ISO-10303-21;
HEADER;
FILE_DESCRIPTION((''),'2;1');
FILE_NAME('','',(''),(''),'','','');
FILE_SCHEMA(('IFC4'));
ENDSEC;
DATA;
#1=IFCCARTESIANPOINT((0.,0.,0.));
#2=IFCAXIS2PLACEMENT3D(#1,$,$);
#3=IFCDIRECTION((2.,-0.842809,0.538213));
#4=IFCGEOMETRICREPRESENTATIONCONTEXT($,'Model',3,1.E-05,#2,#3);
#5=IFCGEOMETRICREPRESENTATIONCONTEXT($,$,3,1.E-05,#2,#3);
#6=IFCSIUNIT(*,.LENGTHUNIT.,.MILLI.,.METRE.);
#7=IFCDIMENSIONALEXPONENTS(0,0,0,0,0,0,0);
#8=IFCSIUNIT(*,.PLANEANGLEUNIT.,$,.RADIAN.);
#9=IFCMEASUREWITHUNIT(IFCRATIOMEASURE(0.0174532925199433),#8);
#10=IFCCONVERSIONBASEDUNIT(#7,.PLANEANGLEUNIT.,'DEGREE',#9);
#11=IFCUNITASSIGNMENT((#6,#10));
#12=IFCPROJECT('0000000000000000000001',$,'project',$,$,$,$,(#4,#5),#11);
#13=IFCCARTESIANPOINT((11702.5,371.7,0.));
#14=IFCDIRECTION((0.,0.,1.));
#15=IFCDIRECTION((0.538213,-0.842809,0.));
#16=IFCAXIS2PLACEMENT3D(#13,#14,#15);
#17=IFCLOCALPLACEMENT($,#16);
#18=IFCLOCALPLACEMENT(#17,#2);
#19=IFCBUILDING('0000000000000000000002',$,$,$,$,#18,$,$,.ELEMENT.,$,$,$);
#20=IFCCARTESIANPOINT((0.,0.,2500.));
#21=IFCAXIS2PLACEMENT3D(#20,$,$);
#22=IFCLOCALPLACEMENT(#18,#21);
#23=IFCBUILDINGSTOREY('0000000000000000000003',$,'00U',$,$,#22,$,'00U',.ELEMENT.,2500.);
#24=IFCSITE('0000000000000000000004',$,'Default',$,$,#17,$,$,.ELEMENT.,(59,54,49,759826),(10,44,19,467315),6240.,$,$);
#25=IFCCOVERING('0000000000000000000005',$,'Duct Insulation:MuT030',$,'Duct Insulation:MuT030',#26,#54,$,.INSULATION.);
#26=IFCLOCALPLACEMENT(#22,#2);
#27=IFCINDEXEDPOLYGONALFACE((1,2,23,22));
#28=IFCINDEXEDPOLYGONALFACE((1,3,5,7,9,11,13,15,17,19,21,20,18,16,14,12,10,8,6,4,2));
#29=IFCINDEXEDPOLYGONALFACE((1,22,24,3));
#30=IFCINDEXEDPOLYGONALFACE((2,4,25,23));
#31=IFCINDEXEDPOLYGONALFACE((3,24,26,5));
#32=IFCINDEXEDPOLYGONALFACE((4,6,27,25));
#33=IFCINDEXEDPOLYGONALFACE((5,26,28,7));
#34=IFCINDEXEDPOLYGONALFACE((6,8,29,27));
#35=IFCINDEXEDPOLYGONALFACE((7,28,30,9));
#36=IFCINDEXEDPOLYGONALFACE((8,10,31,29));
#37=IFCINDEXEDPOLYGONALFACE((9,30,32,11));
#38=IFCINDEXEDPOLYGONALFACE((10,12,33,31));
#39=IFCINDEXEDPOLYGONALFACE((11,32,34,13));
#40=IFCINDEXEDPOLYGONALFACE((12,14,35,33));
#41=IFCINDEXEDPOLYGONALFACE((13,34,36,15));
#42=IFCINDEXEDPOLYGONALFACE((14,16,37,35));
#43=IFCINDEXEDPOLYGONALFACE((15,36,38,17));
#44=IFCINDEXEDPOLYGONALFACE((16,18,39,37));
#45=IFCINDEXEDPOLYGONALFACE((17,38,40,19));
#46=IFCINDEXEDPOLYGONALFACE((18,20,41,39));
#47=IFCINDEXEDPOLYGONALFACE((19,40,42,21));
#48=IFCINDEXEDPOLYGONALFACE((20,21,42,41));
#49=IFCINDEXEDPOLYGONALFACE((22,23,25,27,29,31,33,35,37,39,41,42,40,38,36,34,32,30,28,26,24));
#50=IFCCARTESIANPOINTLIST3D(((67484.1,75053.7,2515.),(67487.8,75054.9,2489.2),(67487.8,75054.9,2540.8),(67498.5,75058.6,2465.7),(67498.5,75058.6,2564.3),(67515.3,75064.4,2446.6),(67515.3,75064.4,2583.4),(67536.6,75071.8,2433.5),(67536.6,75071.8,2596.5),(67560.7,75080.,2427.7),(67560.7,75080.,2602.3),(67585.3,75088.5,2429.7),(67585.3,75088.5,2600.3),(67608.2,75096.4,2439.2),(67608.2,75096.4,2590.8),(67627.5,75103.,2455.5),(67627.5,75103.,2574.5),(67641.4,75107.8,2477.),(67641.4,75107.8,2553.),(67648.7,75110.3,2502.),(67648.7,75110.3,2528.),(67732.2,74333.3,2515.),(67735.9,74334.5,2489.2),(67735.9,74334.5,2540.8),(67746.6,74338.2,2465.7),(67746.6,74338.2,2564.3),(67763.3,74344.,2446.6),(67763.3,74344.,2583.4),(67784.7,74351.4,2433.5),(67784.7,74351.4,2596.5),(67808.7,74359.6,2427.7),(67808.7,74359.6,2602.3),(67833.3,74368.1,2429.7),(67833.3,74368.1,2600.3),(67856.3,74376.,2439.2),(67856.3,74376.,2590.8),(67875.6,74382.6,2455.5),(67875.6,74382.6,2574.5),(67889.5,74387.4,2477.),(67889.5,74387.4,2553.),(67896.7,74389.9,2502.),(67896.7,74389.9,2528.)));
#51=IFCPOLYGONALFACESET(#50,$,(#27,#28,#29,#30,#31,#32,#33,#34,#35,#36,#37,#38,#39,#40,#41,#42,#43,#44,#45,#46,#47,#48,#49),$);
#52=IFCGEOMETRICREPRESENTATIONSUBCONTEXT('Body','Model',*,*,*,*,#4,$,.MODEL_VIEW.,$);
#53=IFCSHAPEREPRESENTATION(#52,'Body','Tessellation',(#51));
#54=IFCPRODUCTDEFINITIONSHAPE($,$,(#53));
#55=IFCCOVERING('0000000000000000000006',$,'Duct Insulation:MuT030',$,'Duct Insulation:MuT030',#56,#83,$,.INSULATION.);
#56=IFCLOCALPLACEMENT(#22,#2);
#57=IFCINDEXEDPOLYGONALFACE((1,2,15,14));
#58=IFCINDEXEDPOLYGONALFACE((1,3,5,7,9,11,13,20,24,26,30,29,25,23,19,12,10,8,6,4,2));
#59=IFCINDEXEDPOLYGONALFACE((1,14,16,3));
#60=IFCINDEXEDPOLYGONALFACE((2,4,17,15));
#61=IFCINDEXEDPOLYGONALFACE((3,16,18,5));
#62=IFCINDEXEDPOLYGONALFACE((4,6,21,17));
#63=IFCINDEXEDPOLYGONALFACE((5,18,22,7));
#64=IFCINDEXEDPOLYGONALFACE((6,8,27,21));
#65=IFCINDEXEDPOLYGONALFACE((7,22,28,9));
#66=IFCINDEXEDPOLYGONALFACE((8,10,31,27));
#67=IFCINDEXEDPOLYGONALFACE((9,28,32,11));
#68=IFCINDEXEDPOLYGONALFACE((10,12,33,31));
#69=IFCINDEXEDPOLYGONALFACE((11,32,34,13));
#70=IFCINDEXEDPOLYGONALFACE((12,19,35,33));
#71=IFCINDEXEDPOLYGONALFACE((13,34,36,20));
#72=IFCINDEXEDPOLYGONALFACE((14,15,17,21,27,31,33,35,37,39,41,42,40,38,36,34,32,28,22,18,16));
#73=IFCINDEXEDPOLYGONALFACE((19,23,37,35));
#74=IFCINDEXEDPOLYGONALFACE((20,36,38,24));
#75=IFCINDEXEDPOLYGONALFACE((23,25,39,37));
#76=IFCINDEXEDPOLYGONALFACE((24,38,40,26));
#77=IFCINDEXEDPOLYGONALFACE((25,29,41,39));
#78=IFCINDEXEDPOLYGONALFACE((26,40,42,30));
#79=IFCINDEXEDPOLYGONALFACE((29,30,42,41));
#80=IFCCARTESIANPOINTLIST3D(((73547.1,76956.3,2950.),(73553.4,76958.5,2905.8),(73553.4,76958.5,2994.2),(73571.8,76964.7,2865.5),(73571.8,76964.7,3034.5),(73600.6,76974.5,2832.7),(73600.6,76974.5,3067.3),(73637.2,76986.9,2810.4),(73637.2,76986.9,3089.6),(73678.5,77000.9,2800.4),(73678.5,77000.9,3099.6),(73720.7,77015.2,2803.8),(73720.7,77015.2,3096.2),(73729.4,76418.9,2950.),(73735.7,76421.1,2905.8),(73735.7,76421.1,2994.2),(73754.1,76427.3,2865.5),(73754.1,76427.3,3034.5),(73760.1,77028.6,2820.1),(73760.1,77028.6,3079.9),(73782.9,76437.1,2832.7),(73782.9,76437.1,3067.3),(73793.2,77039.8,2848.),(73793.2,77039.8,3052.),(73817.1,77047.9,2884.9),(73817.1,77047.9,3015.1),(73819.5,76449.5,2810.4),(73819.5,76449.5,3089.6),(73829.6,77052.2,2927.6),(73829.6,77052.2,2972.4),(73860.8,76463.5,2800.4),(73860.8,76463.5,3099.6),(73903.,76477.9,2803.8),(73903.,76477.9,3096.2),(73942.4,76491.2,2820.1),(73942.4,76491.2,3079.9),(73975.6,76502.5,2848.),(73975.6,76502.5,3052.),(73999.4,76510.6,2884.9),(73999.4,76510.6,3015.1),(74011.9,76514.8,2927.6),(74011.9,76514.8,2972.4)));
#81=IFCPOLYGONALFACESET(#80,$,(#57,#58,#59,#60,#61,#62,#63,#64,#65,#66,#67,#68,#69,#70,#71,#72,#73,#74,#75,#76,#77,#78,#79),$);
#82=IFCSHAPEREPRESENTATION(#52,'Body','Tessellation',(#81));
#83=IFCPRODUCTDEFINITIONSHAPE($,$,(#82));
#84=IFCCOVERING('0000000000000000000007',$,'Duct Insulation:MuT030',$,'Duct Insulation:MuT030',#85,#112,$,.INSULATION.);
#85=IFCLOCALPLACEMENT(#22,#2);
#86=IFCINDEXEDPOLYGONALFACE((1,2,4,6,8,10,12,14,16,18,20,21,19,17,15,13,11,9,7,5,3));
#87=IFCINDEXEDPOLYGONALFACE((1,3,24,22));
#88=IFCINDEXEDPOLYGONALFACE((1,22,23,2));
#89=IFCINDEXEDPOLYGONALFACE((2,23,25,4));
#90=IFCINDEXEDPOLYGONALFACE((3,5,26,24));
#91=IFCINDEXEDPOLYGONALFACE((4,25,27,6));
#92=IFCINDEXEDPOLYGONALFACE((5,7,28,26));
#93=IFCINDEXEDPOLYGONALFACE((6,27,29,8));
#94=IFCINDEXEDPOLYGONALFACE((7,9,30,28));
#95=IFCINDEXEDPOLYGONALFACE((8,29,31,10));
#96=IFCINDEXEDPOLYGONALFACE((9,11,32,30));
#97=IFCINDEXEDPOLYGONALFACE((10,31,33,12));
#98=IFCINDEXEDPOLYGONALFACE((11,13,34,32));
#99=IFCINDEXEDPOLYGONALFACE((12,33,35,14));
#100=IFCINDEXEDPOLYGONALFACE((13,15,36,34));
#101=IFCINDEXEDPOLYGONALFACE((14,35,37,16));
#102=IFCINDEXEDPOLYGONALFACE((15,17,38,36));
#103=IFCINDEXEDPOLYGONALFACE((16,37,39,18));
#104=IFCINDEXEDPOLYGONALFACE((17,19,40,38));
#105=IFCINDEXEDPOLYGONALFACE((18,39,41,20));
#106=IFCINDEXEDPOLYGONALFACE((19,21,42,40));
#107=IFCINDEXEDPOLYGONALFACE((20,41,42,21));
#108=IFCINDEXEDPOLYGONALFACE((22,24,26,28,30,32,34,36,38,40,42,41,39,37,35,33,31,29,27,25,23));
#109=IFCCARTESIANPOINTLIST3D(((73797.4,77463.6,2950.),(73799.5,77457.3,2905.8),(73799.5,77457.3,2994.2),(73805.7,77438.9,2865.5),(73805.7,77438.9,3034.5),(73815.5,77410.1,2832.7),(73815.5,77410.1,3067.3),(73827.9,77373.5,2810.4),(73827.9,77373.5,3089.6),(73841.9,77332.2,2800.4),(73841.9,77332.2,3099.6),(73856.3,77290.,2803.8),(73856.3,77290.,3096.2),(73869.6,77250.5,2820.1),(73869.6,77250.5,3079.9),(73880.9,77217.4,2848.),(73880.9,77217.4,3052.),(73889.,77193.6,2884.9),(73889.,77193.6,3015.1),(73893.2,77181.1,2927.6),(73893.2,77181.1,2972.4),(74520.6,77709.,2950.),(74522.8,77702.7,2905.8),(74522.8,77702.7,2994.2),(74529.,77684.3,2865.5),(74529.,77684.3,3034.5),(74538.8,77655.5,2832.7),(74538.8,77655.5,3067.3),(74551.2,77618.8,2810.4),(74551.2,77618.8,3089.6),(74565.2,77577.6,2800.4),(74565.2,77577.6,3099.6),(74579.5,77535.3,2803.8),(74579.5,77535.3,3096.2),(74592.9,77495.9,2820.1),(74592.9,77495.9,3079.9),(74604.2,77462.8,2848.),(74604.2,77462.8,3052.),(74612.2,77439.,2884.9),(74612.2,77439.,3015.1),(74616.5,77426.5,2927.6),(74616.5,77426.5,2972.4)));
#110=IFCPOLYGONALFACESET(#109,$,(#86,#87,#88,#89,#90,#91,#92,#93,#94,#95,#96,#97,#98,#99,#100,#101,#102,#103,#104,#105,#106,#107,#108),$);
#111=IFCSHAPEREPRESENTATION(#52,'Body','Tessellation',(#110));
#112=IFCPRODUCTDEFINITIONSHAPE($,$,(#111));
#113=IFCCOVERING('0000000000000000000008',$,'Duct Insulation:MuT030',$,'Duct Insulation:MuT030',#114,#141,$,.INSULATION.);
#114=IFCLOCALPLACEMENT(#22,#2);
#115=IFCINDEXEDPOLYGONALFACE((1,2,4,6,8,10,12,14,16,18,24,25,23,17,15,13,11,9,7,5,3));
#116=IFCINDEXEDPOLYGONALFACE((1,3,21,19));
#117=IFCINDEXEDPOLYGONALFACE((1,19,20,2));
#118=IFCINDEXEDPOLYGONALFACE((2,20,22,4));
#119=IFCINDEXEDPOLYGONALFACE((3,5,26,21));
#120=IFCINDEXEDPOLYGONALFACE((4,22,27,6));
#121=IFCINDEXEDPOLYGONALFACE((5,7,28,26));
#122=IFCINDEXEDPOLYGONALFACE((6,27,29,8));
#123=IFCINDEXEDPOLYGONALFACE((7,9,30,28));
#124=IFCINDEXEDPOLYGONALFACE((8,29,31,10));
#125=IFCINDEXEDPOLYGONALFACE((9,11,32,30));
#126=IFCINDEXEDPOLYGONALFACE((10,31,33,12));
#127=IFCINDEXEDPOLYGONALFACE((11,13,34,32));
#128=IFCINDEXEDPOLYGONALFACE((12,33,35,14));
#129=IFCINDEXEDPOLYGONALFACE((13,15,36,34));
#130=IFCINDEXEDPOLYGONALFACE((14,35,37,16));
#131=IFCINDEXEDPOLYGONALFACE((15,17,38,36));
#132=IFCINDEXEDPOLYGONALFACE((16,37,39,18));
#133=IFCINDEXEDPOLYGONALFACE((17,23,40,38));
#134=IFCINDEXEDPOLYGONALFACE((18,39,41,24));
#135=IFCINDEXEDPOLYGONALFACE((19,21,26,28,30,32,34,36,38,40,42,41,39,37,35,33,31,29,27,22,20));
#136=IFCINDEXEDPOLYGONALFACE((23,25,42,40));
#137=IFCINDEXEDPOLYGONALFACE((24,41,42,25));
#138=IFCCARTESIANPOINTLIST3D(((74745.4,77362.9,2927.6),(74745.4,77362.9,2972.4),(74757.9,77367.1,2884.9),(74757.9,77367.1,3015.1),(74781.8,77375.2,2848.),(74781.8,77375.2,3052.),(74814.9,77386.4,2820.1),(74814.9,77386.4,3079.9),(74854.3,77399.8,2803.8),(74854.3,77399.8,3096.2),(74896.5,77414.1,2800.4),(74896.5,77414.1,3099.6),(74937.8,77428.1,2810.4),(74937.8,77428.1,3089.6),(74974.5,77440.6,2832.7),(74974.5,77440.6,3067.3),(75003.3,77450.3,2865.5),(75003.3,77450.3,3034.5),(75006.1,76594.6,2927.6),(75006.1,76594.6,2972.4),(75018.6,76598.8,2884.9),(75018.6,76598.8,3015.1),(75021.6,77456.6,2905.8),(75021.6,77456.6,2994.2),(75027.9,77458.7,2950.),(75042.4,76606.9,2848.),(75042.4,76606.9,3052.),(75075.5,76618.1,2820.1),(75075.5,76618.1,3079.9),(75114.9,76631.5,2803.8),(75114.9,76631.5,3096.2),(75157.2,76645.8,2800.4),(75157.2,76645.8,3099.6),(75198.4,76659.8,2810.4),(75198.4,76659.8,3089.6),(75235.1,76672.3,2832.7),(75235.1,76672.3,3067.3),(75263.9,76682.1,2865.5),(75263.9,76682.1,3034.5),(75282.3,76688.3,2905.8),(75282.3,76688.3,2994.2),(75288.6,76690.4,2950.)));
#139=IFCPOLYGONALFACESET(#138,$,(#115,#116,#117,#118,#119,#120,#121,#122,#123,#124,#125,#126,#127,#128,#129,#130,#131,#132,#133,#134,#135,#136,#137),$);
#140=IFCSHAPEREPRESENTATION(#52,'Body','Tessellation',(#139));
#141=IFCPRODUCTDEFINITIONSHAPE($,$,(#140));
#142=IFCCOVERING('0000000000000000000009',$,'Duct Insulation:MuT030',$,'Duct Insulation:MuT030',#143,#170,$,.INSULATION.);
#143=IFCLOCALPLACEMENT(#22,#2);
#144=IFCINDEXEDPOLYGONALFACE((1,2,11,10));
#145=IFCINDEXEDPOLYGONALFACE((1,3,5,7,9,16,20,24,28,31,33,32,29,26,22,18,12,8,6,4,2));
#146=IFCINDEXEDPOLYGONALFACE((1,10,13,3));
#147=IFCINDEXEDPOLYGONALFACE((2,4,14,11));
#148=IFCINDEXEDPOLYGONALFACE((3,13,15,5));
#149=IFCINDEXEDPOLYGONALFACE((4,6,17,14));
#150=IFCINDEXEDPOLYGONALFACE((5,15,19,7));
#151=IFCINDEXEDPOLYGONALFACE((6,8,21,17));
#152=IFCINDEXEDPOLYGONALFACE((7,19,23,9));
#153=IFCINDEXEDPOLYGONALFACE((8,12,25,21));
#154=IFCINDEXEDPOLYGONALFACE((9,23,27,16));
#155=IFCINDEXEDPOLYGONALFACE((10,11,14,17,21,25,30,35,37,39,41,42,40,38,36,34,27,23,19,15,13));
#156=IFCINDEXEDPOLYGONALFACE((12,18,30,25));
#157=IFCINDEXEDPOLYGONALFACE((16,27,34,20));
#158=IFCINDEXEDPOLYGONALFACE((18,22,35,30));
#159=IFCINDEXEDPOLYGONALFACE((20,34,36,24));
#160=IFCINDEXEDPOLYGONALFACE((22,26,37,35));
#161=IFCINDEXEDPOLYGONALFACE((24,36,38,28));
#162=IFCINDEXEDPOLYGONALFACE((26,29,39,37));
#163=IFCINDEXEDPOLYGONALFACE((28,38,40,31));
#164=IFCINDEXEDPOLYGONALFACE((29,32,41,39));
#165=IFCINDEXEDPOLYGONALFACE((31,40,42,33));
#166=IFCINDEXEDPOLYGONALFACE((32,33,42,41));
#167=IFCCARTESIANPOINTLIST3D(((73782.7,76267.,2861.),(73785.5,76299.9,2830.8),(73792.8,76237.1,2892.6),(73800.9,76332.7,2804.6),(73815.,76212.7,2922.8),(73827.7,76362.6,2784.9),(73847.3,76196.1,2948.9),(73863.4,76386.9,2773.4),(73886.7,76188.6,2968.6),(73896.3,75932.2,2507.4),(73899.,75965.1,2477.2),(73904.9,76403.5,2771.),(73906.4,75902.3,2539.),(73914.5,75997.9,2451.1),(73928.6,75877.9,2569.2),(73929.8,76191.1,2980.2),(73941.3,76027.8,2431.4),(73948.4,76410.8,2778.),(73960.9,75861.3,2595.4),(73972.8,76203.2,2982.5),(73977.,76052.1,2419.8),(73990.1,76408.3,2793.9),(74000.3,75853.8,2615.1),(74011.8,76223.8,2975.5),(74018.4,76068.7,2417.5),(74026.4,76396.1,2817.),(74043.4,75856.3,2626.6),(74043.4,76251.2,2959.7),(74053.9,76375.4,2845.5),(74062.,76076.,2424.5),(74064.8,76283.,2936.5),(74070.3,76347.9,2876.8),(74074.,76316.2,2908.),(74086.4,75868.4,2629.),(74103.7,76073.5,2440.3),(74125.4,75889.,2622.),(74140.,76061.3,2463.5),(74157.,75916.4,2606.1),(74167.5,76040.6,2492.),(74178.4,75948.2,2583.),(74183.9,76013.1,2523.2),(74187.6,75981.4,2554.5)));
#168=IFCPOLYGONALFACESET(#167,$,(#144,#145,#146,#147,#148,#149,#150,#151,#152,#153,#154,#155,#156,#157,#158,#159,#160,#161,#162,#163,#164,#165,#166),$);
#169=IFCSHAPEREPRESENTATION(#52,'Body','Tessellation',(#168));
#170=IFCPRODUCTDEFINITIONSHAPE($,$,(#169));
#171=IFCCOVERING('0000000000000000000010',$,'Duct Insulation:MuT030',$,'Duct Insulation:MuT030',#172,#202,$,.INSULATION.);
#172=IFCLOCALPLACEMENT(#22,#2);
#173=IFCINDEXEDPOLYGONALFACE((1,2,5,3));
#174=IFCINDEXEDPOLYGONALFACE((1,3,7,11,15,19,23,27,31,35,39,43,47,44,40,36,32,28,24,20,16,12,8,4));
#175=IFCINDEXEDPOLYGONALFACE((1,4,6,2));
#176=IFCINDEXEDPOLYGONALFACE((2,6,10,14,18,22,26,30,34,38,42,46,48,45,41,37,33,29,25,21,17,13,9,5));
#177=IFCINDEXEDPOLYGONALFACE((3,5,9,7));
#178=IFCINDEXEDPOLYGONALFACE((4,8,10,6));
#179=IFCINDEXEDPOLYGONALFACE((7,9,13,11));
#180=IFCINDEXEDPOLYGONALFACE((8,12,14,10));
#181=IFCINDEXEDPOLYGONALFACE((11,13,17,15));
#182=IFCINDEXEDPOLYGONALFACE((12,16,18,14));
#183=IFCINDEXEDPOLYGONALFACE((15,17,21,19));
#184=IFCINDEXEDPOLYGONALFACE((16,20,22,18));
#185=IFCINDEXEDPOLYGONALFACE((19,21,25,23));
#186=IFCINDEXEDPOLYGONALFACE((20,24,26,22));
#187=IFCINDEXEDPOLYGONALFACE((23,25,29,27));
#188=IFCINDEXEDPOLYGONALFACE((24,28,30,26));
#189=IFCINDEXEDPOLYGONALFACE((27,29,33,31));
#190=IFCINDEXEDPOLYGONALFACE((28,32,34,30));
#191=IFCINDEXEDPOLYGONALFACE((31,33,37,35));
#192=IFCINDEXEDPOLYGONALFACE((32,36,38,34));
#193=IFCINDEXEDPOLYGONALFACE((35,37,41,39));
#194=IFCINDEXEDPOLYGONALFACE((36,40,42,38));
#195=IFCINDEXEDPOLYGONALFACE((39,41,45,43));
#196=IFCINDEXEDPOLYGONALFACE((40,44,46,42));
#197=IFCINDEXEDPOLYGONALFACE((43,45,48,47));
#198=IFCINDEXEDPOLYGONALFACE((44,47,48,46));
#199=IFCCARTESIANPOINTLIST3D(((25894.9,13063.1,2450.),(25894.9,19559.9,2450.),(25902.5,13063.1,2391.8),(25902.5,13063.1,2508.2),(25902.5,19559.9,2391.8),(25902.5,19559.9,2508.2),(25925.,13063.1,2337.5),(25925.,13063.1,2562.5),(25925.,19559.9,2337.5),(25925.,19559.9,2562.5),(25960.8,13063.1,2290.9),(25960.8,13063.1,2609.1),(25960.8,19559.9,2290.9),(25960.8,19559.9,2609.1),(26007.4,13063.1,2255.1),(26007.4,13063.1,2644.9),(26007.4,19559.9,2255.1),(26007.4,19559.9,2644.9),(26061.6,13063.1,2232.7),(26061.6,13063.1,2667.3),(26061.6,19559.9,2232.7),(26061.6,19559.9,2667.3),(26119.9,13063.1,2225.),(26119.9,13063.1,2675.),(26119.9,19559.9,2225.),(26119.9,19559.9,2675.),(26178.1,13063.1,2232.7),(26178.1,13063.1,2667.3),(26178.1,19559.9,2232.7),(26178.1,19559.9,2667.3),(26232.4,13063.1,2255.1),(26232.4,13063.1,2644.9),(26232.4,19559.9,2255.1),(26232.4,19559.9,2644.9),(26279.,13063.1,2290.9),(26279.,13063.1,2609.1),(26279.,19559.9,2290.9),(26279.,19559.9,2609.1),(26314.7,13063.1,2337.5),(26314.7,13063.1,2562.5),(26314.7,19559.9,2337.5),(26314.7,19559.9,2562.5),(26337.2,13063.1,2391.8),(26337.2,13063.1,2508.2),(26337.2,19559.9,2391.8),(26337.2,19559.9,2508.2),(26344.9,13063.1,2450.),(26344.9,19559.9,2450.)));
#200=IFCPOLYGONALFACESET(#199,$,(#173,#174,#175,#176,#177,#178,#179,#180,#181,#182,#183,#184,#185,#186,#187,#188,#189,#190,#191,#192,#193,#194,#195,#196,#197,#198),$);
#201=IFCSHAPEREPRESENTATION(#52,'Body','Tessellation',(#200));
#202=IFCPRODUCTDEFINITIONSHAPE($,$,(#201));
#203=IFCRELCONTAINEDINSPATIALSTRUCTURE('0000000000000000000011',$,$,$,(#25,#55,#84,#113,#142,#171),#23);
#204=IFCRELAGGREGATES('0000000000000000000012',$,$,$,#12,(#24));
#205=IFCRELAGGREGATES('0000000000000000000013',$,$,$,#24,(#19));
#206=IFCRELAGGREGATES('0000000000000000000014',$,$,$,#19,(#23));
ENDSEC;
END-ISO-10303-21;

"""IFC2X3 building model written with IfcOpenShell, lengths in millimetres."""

from ifc_helpers import new_model, entity, si_unit, converted_unit, direction, frame, frame_2d, origin, origin_2d_with_axis, place, context, subcontext, project, spatial, circle, extrude, element, save


model = new_model("IFC2X3")

# Units and contexts
model_context = context("Model", 3, precision=1e-05, world=origin(), true_north=direction((2.0, -0.842809, 0.538213)))
context_of_model = context(None, 3, precision=1e-05, world=origin(), true_north=direction((2.0, -0.842809, 0.538213)))
body_context = subcontext(model_context, "Body", "Model", "MODEL_VIEW")
ifc_project = project(units=[si_unit("LENGTHUNIT", "METRE", prefix="MILLI"), converted_unit("PLANEANGLEUNIT", "DEGREE", entity("IfcRatioMeasure", 0.0174532925199433), si_unit("PLANEANGLEUNIT", "RADIAN"), dimensions=[0, 0, 0, 0, 0, 0, 0])], contexts=[model_context, context_of_model])

# Site, building, storey
site_placement = place(None, frame((11702.5, 371.7, 0.0), z_axis=(0.0, 0.0, 1.0), x_axis=(0.538213, -0.842809, 0.0)))
site = spatial("IfcSite", under=ifc_project, at=site_placement, Name="Default", CompositionType="ELEMENT", RefLatitude=(59, 54, 49, 759826), RefLongitude=(10, 44, 19, 467315), RefElevation=6240.0)
building_placement = place(site_placement, origin())
building = spatial("IfcBuilding", under=site, at=building_placement, CompositionType="ELEMENT")
storey_placement = place(building_placement, frame((0.0, 0.0, 2500.0)))
storey = spatial("IfcBuildingStorey", under=building, at=storey_placement, Name="00U", LongName="00U", CompositionType="ELEMENT", Elevation=2500.0)

# Coverings
covering_1_placement = place(storey_placement, origin())
element("IfcCovering", 1, at=covering_1_placement, inside=storey, Name="Duct Insulation:MuT030", ObjectType="Duct Insulation:MuT030", PredefinedType="INSULATION", context=body_context, shape_type="SweptSolid", body=[
    extrude(circle(Radius=87.5, at=origin_2d_with_axis()), frame((67814.9, 74361.8, 2515.0), z_axis=(-0.325568, 0.945519, 0.0), x_axis=(-0.945519, -0.325568, 0.0)), (0.0, 0.0, 1.0), 761.9),
])
covering_2_placement = place(storey_placement, origin())
element("IfcCovering", 2, at=covering_2_placement, inside=storey, Name="Duct Insulation:MuT030", ObjectType="Duct Insulation:MuT030", PredefinedType="INSULATION", context=body_context, shape_type="SweptSolid", body=[
    extrude(circle(Radius=150.0, at=origin_2d_with_axis()), frame((73871.4, 76467.1, 2950.0), z_axis=(-0.321274, 0.946986, 0.0), x_axis=(-0.946986, -0.321274, 0.0)), (0.0, 0.0, 1.0), 567.4),
])
covering_3_placement = place(storey_placement, origin())
element("IfcCovering", 3, at=covering_3_placement, inside=storey, Name="Duct Insulation:MuT030", ObjectType="Duct Insulation:MuT030", PredefinedType="INSULATION", context=body_context, shape_type="SweptSolid", body=[
    extrude(circle(Radius=150.0, at=frame_2d((0.0, 0.0), x_axis=(1.0, 0.0))), frame((73845.5, 77321.6, 2950.0), z_axis=(0.946986, 0.321274, 0.0), x_axis=(-0.321274, 0.946986, 0.0)), (0.0, 0.0, 1.0), 763.8),
])
covering_4_placement = place(storey_placement, origin())
element("IfcCovering", 4, at=covering_4_placement, inside=storey, Name="Duct Insulation:MuT030", ObjectType="Duct Insulation:MuT030", PredefinedType="INSULATION", context=body_context, shape_type="SweptSolid", body=[
    extrude(circle(Radius=150.0, at=frame_2d((0.0, 0.0), x_axis=(1.0, 0.0))), frame((75146.5, 76642.2, 2950.0), z_axis=(-0.321274, 0.946986, 0.0), x_axis=(0.946986, 0.321274, 0.0)), (0.0, 0.0, 1.0), 811.3),
])
covering_5_placement = place(storey_placement, origin())
element("IfcCovering", 5, at=covering_5_placement, inside=storey, Name="Duct Insulation:MuT030", ObjectType="Duct Insulation:MuT030", PredefinedType="INSULATION", context=body_context, shape_type="SweptSolid", body=[
    extrude(circle(Radius=150.0, at=frame_2d((0.0, 0.0), x_axis=(1.0, 0.0))), frame((74041.8, 75964.9, 2523.2), z_axis=(-0.227175, 0.66962, 0.707107), x_axis=(0.946986, 0.321274, 0.0)), (0.0, 0.0, 1.0), 500.0),
])
covering_6_placement = place(storey_placement, origin())
element("IfcCovering", 6, at=covering_6_placement, inside=storey, Name="Duct Insulation:MuT030", ObjectType="Duct Insulation:MuT030", PredefinedType="INSULATION", context=body_context, shape_type="SweptSolid", body=[
    extrude(circle(Radius=225.0, at=frame_2d((0.0, 0.0), x_axis=(1.0, 0.0))), frame((26119.9, 13063.1, 2450.0), z_axis=(0.0, 1.0, 0.0), x_axis=(1.0, 0.0, 0.0)), (0.0, 0.0, 1.0), 6496.9),
])

save(model, "model.ifc")
